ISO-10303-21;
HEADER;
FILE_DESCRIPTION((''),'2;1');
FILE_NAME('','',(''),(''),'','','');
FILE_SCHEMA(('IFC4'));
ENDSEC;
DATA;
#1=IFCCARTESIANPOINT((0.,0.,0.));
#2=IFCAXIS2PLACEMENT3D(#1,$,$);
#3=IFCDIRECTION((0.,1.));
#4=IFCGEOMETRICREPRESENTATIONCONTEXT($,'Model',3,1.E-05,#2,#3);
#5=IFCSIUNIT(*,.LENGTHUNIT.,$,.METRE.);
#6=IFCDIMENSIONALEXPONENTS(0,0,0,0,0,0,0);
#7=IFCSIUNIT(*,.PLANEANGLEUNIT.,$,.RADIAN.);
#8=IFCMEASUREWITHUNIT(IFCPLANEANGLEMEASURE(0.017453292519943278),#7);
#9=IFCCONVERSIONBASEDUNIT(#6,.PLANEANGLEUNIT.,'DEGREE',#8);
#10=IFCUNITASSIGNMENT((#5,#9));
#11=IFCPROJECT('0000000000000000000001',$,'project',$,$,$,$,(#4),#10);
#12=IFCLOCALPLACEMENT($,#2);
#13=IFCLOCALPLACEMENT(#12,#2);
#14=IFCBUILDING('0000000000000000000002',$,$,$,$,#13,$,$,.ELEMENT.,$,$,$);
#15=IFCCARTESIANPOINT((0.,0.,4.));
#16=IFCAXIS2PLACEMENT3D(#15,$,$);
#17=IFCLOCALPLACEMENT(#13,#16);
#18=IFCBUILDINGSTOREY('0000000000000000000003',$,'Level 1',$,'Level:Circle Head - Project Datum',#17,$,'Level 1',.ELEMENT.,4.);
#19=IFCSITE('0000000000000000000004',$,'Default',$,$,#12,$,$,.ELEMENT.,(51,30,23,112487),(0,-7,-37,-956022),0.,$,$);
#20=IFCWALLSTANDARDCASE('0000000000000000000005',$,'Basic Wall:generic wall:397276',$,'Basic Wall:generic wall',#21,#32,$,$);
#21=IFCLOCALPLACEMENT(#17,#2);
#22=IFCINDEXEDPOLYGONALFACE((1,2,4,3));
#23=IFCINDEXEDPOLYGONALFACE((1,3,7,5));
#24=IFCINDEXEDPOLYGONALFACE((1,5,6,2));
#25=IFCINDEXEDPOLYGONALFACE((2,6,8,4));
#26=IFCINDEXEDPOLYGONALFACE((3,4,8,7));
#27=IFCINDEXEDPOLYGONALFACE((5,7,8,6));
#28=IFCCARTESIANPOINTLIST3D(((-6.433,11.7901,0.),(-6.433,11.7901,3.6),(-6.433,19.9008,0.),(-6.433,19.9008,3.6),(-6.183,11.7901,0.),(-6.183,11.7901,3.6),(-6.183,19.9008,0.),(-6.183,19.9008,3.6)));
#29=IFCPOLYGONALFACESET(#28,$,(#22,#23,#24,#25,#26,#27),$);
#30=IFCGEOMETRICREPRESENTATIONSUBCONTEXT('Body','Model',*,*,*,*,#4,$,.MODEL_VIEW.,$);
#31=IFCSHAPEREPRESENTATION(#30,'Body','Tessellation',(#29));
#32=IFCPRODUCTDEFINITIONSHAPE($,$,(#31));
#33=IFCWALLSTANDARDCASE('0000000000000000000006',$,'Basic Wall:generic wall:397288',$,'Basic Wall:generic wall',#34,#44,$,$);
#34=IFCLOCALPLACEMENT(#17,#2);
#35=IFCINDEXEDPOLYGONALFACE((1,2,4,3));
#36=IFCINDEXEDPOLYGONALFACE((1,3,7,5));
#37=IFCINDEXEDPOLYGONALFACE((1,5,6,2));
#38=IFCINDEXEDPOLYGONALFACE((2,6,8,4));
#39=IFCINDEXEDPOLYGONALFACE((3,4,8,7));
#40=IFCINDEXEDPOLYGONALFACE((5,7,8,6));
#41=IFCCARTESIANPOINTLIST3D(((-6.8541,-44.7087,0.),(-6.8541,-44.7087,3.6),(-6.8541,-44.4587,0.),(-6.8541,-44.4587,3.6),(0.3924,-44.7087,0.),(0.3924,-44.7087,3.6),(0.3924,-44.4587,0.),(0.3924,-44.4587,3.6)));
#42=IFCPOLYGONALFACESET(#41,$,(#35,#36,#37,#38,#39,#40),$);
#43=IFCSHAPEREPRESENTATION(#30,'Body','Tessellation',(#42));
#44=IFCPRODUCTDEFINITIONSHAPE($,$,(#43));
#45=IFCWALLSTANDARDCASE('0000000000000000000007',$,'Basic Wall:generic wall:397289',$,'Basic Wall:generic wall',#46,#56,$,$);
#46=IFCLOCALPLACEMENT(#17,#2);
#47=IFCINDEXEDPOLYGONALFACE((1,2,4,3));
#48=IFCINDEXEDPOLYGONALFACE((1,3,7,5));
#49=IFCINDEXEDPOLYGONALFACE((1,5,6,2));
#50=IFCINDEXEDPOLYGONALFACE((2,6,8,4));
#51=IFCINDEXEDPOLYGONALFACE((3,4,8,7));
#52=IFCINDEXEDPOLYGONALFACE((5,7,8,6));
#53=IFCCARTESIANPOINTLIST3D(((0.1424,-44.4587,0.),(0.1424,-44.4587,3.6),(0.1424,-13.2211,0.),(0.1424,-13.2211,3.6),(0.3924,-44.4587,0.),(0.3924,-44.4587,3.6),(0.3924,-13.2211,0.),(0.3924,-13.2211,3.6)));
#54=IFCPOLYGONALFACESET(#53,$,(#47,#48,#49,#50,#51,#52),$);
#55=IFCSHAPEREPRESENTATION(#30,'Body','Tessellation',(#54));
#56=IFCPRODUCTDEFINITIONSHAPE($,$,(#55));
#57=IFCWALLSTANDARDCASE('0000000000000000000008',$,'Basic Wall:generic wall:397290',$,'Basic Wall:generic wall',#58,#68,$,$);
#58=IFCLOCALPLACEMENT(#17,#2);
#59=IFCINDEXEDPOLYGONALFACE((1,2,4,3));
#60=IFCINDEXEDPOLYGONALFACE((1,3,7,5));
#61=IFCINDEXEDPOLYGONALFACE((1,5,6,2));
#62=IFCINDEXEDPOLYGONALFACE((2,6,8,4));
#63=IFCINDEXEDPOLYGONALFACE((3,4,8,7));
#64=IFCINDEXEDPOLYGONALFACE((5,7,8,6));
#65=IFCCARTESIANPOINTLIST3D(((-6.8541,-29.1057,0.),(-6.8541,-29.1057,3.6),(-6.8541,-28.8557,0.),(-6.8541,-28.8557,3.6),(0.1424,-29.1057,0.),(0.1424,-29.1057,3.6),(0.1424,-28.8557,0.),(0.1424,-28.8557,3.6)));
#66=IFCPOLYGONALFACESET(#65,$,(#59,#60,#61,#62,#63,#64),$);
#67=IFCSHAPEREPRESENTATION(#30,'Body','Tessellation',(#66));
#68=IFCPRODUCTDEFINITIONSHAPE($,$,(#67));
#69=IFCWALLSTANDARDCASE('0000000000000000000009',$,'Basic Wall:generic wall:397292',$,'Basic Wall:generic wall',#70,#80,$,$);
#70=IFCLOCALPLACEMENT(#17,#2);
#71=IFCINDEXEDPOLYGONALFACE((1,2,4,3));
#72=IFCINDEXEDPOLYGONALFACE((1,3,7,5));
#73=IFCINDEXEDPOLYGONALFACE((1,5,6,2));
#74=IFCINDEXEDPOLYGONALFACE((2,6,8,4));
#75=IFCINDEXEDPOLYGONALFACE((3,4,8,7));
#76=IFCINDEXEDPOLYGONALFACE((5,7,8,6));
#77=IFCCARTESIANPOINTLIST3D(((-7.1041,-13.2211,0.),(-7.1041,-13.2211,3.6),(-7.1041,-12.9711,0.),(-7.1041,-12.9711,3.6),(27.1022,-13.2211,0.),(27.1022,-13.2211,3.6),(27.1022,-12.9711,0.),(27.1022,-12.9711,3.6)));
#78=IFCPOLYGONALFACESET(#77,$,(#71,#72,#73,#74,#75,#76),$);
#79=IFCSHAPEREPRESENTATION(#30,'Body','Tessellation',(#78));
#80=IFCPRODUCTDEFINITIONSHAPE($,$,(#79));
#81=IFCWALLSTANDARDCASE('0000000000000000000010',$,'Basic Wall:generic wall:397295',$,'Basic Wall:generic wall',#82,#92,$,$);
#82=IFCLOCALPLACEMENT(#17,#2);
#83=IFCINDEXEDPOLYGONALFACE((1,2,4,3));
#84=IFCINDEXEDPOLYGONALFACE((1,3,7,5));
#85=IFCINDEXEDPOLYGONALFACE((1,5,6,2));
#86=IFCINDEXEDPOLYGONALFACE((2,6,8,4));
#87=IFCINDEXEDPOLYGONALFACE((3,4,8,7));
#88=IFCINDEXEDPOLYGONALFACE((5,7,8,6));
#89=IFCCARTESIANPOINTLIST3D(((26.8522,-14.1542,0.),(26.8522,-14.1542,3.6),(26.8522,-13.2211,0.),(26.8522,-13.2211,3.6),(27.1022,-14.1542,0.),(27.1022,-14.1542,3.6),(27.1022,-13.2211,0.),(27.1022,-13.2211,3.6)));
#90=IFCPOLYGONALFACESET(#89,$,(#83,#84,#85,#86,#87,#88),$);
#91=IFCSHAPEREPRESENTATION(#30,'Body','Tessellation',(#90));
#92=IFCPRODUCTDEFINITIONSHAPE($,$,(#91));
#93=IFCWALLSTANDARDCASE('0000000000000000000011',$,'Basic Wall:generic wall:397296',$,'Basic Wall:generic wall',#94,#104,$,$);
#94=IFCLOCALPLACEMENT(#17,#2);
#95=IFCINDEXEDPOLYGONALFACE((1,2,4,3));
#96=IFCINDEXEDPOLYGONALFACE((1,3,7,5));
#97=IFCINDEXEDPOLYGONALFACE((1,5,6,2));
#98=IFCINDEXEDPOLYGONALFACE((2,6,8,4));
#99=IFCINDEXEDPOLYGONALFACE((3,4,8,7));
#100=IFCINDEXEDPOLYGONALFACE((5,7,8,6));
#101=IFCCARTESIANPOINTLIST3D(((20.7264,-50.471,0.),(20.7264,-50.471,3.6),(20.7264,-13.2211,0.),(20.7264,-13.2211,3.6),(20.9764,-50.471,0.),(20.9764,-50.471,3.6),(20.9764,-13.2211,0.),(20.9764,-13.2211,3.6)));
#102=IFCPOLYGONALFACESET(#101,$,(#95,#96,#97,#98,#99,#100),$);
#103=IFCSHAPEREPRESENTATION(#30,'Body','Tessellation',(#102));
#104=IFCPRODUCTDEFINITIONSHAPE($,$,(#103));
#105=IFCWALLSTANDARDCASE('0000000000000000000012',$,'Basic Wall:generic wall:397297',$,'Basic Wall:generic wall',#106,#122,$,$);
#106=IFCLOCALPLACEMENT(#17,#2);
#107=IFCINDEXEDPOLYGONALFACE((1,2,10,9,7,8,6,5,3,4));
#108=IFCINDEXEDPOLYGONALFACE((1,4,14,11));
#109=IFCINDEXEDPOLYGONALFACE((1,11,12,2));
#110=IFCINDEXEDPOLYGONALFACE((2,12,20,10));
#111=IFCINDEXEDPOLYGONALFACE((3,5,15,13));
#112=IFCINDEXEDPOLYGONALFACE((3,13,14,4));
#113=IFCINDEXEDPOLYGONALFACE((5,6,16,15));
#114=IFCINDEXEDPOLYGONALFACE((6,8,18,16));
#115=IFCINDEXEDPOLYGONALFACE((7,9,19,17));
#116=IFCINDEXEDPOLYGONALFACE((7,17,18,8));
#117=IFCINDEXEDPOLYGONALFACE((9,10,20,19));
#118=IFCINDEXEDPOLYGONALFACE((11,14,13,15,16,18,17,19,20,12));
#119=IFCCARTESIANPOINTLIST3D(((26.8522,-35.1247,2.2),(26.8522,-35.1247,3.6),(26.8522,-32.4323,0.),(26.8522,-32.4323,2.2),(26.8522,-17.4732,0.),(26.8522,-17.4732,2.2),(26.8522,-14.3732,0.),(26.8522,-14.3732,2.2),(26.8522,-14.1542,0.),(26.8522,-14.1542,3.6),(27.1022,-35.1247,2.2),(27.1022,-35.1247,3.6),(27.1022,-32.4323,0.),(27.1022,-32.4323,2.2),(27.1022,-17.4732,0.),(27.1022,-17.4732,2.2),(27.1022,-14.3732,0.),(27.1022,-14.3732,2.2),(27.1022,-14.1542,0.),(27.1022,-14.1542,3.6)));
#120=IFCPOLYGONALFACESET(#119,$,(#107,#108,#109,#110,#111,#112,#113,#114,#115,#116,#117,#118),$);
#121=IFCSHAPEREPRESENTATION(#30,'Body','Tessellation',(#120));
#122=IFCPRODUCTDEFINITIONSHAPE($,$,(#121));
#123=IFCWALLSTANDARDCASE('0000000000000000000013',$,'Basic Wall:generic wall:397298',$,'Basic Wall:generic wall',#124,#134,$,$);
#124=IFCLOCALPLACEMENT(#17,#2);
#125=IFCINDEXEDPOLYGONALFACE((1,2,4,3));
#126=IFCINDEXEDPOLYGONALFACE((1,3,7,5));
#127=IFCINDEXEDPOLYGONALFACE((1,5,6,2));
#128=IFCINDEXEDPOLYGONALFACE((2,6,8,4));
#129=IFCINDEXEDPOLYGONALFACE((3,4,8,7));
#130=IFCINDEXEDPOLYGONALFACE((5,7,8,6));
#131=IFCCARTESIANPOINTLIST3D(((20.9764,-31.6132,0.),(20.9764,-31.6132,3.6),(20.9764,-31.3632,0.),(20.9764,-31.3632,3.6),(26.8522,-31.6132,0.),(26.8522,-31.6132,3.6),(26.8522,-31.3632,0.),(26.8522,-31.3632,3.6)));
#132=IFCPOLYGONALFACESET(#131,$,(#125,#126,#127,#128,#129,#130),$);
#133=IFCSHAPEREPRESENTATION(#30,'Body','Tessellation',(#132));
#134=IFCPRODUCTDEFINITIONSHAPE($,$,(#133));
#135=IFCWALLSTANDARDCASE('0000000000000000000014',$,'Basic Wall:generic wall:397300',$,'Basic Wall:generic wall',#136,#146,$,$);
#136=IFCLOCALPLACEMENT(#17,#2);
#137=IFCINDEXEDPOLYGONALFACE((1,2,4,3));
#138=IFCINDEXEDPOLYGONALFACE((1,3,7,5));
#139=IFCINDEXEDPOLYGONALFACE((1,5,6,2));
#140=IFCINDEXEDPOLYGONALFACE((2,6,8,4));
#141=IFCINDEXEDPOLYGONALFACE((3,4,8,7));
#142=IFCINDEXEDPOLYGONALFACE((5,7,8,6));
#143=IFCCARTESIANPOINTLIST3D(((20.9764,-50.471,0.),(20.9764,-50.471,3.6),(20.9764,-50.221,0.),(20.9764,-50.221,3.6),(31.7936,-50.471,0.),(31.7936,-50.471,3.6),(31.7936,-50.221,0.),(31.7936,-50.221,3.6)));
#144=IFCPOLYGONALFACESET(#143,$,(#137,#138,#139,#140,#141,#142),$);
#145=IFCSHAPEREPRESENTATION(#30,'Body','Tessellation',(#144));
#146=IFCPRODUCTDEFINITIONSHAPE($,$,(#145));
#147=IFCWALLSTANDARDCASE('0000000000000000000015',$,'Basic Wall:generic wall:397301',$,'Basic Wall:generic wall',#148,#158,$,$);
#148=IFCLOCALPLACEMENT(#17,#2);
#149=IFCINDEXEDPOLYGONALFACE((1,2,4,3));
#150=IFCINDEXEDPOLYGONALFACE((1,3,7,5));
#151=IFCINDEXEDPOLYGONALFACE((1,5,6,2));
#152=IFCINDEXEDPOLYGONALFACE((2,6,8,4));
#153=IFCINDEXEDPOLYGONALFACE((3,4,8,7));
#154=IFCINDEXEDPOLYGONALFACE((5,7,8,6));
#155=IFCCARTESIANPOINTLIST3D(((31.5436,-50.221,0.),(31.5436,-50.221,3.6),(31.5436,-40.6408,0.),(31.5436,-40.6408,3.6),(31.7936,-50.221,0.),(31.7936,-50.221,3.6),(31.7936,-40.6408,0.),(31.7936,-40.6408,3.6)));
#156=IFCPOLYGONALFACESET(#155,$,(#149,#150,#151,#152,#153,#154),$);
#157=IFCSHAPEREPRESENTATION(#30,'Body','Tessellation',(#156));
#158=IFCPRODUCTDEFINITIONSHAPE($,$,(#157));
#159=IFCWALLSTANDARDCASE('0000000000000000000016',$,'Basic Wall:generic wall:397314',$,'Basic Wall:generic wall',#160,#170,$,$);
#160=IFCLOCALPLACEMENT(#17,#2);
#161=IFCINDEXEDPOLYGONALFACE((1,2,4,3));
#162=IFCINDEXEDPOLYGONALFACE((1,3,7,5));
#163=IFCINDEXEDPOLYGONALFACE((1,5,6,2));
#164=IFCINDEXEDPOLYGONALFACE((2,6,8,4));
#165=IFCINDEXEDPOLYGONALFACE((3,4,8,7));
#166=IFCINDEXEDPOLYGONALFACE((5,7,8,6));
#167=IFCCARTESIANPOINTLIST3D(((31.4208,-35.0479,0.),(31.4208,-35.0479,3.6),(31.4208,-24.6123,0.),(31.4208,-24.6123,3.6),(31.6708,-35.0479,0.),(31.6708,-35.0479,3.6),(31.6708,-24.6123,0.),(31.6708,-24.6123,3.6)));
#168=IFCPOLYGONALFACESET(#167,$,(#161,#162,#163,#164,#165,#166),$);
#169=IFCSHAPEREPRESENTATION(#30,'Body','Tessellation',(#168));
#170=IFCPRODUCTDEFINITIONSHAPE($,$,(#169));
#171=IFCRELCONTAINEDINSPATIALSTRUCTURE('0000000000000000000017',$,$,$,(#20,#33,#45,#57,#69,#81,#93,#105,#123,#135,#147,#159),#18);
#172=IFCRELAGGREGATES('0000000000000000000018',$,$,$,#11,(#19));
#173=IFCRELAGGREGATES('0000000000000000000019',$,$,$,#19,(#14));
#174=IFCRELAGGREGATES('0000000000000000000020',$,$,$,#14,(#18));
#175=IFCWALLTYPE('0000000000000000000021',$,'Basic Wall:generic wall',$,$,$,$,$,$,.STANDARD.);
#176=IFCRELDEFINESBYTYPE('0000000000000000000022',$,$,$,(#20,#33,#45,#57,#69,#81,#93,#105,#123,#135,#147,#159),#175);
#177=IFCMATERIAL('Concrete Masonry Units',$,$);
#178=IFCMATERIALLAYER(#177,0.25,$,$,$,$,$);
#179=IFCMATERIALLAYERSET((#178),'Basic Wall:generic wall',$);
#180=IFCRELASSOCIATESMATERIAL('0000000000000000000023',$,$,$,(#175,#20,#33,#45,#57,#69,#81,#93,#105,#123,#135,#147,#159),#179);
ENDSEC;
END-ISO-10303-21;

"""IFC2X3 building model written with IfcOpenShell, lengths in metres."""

from ifc_helpers import new_model, entity, si_unit, converted_unit, direction, frame, frame_2d, origin, place, context, subcontext, project, spatial, rectangle, extrude, material, layer, layer_set, layer_usage, type_object, element, save


model = new_model("IFC2X3")

# Units and contexts
model_context = context("Model", 3, precision=1e-05, world=origin(), true_north=direction((0.0, 1.0)))
body_context = subcontext(model_context, "Body", "Model", "MODEL_VIEW")
ifc_project = project(units=[si_unit("LENGTHUNIT", "METRE"), converted_unit("PLANEANGLEUNIT", "DEGREE", entity("IfcPlaneAngleMeasure", 0.017453292519943278), si_unit("PLANEANGLEUNIT", "RADIAN"), dimensions=[0, 0, 0, 0, 0, 0, 0])], contexts=[model_context])

# Site, building, storey
site_placement = place(None, origin())
site = spatial("IfcSite", under=ifc_project, at=site_placement, Name="Default", CompositionType="ELEMENT", RefLatitude=(51, 30, 23, 112487), RefLongitude=(0, -7, -37, -956022), RefElevation=0.0)
building_placement = place(site_placement, origin())
building = spatial("IfcBuilding", under=site, at=building_placement, CompositionType="ELEMENT")
storey_placement = place(building_placement, frame((0.0, 0.0, 4.0)))
storey = spatial("IfcBuildingStorey", under=building, at=storey_placement, Name="Level 1", ObjectType="Level:Circle Head - Project Datum", LongName="Level 1", CompositionType="ELEMENT", Elevation=4.0)

# Walls
ifc_material_1 = material(Name="Concrete Masonry Units")
ifc_layer_1 = layer(ifc_material_1, 0.25)
ifc_layer_set_1 = layer_set([ifc_layer_1], Name="Basic Wall:generic wall")
ifc_layer_usage_1 = layer_usage(ifc_layer_set_1, "AXIS2", "NEGATIVE", 0.125)
wall_type_1 = type_object("IfcWallType", Name="Basic Wall:generic wall", PredefinedType="STANDARD", material=ifc_layer_set_1)
wall_1_placement = place(storey_placement, frame((-6.308, 19.9008, 0.0), z_axis=(0.0, 0.0, 1.0), x_axis=(0.0, -1.0, 0.0)))
element("IfcWallStandardCase", 1, at=wall_1_placement, inside=storey, type_object=wall_type_1, material=ifc_layer_usage_1, Name="Basic Wall:generic wall:397276", ObjectType="Basic Wall:generic wall", context=body_context, shape_type="SweptSolid", body=[
    extrude(rectangle(XDim=8.1107, YDim=0.25, at=frame_2d((4.0554, 0.0), x_axis=(-1.0, 0.0))), origin(), (0.0, 0.0, 1.0), 3.6),
])
ifc_layer_usage_2 = layer_usage(ifc_layer_set_1, "AXIS2", "NEGATIVE", 0.125)
wall_2_placement = place(storey_placement, frame((-6.8541, -44.5837, 0.0)))
element("IfcWallStandardCase", 2, at=wall_2_placement, inside=storey, type_object=wall_type_1, material=ifc_layer_usage_2, Name="Basic Wall:generic wall:397288", ObjectType="Basic Wall:generic wall", context=body_context, shape_type="SweptSolid", body=[
    extrude(rectangle(XDim=7.2466, YDim=0.25, at=frame_2d((3.6233, 0.0), x_axis=(-1.0, 0.0))), origin(), (0.0, 0.0, 1.0), 3.6),
])
ifc_layer_usage_3 = layer_usage(ifc_layer_set_1, "AXIS2", "NEGATIVE", 0.125)
wall_3_placement = place(storey_placement, frame((0.2674, -44.4587, 0.0), z_axis=(0.0, 0.0, 1.0), x_axis=(0.0, 1.0, 0.0)))
element("IfcWallStandardCase", 3, at=wall_3_placement, inside=storey, type_object=wall_type_1, material=ifc_layer_usage_3, Name="Basic Wall:generic wall:397289", ObjectType="Basic Wall:generic wall", context=body_context, shape_type="SweptSolid", body=[
    extrude(rectangle(XDim=31.2376, YDim=0.25, at=frame_2d((15.6188, 0.0), x_axis=(-1.0, 0.0))), origin(), (0.0, 0.0, 1.0), 3.6),
])
ifc_layer_usage_4 = layer_usage(ifc_layer_set_1, "AXIS2", "NEGATIVE", 0.125)
wall_4_placement = place(storey_placement, frame((0.1424, -28.9807, 0.0), z_axis=(0.0, 0.0, 1.0), x_axis=(-1.0, 0.0, 0.0)))
element("IfcWallStandardCase", 4, at=wall_4_placement, inside=storey, type_object=wall_type_1, material=ifc_layer_usage_4, Name="Basic Wall:generic wall:397290", ObjectType="Basic Wall:generic wall", context=body_context, shape_type="SweptSolid", body=[
    extrude(rectangle(XDim=6.9966, YDim=0.25, at=frame_2d((3.4983, 0.0), x_axis=(-1.0, 0.0))), origin(), (0.0, 0.0, 1.0), 3.6),
])
ifc_layer_usage_5 = layer_usage(ifc_layer_set_1, "AXIS2", "NEGATIVE", 0.125)
wall_5_placement = place(storey_placement, frame((27.1022, -13.0961, 0.0), z_axis=(0.0, 0.0, 1.0), x_axis=(-1.0, 0.0, 0.0)))
element("IfcWallStandardCase", 5, at=wall_5_placement, inside=storey, type_object=wall_type_1, material=ifc_layer_usage_5, Name="Basic Wall:generic wall:397292", ObjectType="Basic Wall:generic wall", context=body_context, shape_type="SweptSolid", body=[
    extrude(rectangle(XDim=34.2063, YDim=0.25, at=frame_2d((17.1032, 0.0), x_axis=(-1.0, 0.0))), origin(), (0.0, 0.0, 1.0), 3.6),
])
ifc_layer_usage_6 = layer_usage(ifc_layer_set_1, "AXIS2", "NEGATIVE", 0.125)
wall_6_placement = place(storey_placement, frame((26.9772, -13.2211, 0.0), z_axis=(0.0, 0.0, 1.0), x_axis=(0.0, -1.0, 0.0)))
element("IfcWallStandardCase", 6, at=wall_6_placement, inside=storey, type_object=wall_type_1, material=ifc_layer_usage_6, Name="Basic Wall:generic wall:397295", ObjectType="Basic Wall:generic wall", context=body_context, shape_type="SweptSolid", body=[
    extrude(rectangle(XDim=0.9331, YDim=0.25, at=frame_2d((0.4665, 0.0), x_axis=(-1.0, 0.0))), origin(), (0.0, 0.0, 1.0), 3.6),
])
ifc_layer_usage_7 = layer_usage(ifc_layer_set_1, "AXIS2", "NEGATIVE", 0.125)
wall_7_placement = place(storey_placement, frame((20.8514, -13.2211, 0.0), z_axis=(0.0, 0.0, 1.0), x_axis=(0.0, -1.0, 0.0)))
element("IfcWallStandardCase", 7, at=wall_7_placement, inside=storey, type_object=wall_type_1, material=ifc_layer_usage_7, Name="Basic Wall:generic wall:397296", ObjectType="Basic Wall:generic wall", context=body_context, shape_type="SweptSolid", body=[
    extrude(rectangle(XDim=37.2499, YDim=0.25, at=frame_2d((18.6249, 0.0), x_axis=(-1.0, 0.0))), origin(), (0.0, 0.0, 1.0), 3.6),
])

# Wall, openings
ifc_layer_usage_8 = layer_usage(ifc_layer_set_1, "AXIS2", "NEGATIVE", 0.125)
wall_8_placement = place(storey_placement, frame((26.9772, -14.1542, 0.0), z_axis=(0.0, 0.0, 1.0), x_axis=(0.0, -1.0, 0.0)))
wall_8 = element("IfcWallStandardCase", 8, at=wall_8_placement, inside=storey, type_object=wall_type_1, material=ifc_layer_usage_8, Name="Basic Wall:generic wall:397297", ObjectType="Basic Wall:generic wall", context=body_context, shape_type="SweptSolid", body=[
    extrude(rectangle(XDim=20.9705, YDim=0.25, at=frame_2d((10.4852, 0.0), x_axis=(-1.0, 0.0))), origin(), (0.0, 0.0, 1.0), 3.6),
])
opening_1_placement = place(wall_8_placement, frame((21.3781, 0.125, 0.0)))
element("IfcOpeningElement", 9, at=opening_1_placement, cuts=wall_8, ObjectType="Opening", context=body_context, shape_type="SweptSolid", body=[
    extrude(rectangle(XDim=2.2, YDim=3.1, at=frame_2d((1.1, 1.55), x_axis=(1.0, 0.0))), frame((0.0, 0.0, 0.0), z_axis=(0.0, -1.0, 0.0), x_axis=(0.0, 0.0, 1.0)), (0.0, 0.0, 1.0), 0.25),
])
opening_2_placement = place(wall_8_placement, frame((3.3191, 0.125, 0.0)))
element("IfcOpeningElement", 10, at=opening_2_placement, cuts=wall_8, ObjectType="Opening", context=body_context, shape_type="SweptSolid", body=[
    extrude(rectangle(XDim=2.2, YDim=3.1, at=frame_2d((1.1, 1.55), x_axis=(1.0, 0.0))), frame((0.0, 0.0, 0.0), z_axis=(0.0, -1.0, 0.0), x_axis=(0.0, 0.0, 1.0)), (0.0, 0.0, 1.0), 0.25),
])

# Wall
ifc_layer_usage_9 = layer_usage(ifc_layer_set_1, "AXIS2", "NEGATIVE", 0.125)
wall_9_placement = place(storey_placement, frame((26.8522, -31.4882, 0.0), z_axis=(0.0, 0.0, 1.0), x_axis=(-1.0, 0.0, 0.0)))
element("IfcWallStandardCase", 11, at=wall_9_placement, inside=storey, type_object=wall_type_1, material=ifc_layer_usage_9, Name="Basic Wall:generic wall:397298", ObjectType="Basic Wall:generic wall", context=body_context, shape_type="SweptSolid", body=[
    extrude(rectangle(XDim=5.8758, YDim=0.25, at=frame_2d((2.9379, 0.0), x_axis=(-1.0, 0.0))), origin(), (0.0, 0.0, 1.0), 3.6),
])

# Walls
ifc_layer_usage_10 = layer_usage(ifc_layer_set_1, "AXIS2", "NEGATIVE", 0.125)
wall_10_placement = place(storey_placement, frame((20.9764, -50.346, 0.0)))
element("IfcWallStandardCase", 12, at=wall_10_placement, inside=storey, type_object=wall_type_1, material=ifc_layer_usage_10, Name="Basic Wall:generic wall:397300", ObjectType="Basic Wall:generic wall", context=body_context, shape_type="SweptSolid", body=[
    extrude(rectangle(XDim=10.8172, YDim=0.25, at=frame_2d((5.4086, 0.0), x_axis=(-1.0, 0.0))), origin(), (0.0, 0.0, 1.0), 3.6),
])
ifc_layer_usage_11 = layer_usage(ifc_layer_set_1, "AXIS2", "NEGATIVE", 0.125)
wall_11_placement = place(storey_placement, frame((31.6686, -50.221, 0.0), z_axis=(0.0, 0.0, 1.0), x_axis=(0.0, 1.0, 0.0)))
element("IfcWallStandardCase", 13, at=wall_11_placement, inside=storey, type_object=wall_type_1, material=ifc_layer_usage_11, Name="Basic Wall:generic wall:397301", ObjectType="Basic Wall:generic wall", context=body_context, shape_type="SweptSolid", body=[
    extrude(rectangle(XDim=9.5802, YDim=0.25, at=frame_2d((4.7901, 0.0), x_axis=(-1.0, 0.0))), origin(), (0.0, 0.0, 1.0), 3.6),
])
ifc_layer_usage_12 = layer_usage(ifc_layer_set_1, "AXIS2", "NEGATIVE", 0.125)
wall_12_placement = place(storey_placement, frame((31.5458, -35.0479, 0.0), z_axis=(0.0, 0.0, 1.0), x_axis=(0.0, 1.0, 0.0)))
element("IfcWallStandardCase", 14, at=wall_12_placement, inside=storey, type_object=wall_type_1, material=ifc_layer_usage_12, Name="Basic Wall:generic wall:397314", ObjectType="Basic Wall:generic wall", context=body_context, shape_type="SweptSolid", body=[
    extrude(rectangle(XDim=10.4356, YDim=0.25, at=frame_2d((5.2178, 0.0), x_axis=(-1.0, 0.0))), origin(), (0.0, 0.0, 1.0), 3.6),
])

save(model, "model.ifc")
